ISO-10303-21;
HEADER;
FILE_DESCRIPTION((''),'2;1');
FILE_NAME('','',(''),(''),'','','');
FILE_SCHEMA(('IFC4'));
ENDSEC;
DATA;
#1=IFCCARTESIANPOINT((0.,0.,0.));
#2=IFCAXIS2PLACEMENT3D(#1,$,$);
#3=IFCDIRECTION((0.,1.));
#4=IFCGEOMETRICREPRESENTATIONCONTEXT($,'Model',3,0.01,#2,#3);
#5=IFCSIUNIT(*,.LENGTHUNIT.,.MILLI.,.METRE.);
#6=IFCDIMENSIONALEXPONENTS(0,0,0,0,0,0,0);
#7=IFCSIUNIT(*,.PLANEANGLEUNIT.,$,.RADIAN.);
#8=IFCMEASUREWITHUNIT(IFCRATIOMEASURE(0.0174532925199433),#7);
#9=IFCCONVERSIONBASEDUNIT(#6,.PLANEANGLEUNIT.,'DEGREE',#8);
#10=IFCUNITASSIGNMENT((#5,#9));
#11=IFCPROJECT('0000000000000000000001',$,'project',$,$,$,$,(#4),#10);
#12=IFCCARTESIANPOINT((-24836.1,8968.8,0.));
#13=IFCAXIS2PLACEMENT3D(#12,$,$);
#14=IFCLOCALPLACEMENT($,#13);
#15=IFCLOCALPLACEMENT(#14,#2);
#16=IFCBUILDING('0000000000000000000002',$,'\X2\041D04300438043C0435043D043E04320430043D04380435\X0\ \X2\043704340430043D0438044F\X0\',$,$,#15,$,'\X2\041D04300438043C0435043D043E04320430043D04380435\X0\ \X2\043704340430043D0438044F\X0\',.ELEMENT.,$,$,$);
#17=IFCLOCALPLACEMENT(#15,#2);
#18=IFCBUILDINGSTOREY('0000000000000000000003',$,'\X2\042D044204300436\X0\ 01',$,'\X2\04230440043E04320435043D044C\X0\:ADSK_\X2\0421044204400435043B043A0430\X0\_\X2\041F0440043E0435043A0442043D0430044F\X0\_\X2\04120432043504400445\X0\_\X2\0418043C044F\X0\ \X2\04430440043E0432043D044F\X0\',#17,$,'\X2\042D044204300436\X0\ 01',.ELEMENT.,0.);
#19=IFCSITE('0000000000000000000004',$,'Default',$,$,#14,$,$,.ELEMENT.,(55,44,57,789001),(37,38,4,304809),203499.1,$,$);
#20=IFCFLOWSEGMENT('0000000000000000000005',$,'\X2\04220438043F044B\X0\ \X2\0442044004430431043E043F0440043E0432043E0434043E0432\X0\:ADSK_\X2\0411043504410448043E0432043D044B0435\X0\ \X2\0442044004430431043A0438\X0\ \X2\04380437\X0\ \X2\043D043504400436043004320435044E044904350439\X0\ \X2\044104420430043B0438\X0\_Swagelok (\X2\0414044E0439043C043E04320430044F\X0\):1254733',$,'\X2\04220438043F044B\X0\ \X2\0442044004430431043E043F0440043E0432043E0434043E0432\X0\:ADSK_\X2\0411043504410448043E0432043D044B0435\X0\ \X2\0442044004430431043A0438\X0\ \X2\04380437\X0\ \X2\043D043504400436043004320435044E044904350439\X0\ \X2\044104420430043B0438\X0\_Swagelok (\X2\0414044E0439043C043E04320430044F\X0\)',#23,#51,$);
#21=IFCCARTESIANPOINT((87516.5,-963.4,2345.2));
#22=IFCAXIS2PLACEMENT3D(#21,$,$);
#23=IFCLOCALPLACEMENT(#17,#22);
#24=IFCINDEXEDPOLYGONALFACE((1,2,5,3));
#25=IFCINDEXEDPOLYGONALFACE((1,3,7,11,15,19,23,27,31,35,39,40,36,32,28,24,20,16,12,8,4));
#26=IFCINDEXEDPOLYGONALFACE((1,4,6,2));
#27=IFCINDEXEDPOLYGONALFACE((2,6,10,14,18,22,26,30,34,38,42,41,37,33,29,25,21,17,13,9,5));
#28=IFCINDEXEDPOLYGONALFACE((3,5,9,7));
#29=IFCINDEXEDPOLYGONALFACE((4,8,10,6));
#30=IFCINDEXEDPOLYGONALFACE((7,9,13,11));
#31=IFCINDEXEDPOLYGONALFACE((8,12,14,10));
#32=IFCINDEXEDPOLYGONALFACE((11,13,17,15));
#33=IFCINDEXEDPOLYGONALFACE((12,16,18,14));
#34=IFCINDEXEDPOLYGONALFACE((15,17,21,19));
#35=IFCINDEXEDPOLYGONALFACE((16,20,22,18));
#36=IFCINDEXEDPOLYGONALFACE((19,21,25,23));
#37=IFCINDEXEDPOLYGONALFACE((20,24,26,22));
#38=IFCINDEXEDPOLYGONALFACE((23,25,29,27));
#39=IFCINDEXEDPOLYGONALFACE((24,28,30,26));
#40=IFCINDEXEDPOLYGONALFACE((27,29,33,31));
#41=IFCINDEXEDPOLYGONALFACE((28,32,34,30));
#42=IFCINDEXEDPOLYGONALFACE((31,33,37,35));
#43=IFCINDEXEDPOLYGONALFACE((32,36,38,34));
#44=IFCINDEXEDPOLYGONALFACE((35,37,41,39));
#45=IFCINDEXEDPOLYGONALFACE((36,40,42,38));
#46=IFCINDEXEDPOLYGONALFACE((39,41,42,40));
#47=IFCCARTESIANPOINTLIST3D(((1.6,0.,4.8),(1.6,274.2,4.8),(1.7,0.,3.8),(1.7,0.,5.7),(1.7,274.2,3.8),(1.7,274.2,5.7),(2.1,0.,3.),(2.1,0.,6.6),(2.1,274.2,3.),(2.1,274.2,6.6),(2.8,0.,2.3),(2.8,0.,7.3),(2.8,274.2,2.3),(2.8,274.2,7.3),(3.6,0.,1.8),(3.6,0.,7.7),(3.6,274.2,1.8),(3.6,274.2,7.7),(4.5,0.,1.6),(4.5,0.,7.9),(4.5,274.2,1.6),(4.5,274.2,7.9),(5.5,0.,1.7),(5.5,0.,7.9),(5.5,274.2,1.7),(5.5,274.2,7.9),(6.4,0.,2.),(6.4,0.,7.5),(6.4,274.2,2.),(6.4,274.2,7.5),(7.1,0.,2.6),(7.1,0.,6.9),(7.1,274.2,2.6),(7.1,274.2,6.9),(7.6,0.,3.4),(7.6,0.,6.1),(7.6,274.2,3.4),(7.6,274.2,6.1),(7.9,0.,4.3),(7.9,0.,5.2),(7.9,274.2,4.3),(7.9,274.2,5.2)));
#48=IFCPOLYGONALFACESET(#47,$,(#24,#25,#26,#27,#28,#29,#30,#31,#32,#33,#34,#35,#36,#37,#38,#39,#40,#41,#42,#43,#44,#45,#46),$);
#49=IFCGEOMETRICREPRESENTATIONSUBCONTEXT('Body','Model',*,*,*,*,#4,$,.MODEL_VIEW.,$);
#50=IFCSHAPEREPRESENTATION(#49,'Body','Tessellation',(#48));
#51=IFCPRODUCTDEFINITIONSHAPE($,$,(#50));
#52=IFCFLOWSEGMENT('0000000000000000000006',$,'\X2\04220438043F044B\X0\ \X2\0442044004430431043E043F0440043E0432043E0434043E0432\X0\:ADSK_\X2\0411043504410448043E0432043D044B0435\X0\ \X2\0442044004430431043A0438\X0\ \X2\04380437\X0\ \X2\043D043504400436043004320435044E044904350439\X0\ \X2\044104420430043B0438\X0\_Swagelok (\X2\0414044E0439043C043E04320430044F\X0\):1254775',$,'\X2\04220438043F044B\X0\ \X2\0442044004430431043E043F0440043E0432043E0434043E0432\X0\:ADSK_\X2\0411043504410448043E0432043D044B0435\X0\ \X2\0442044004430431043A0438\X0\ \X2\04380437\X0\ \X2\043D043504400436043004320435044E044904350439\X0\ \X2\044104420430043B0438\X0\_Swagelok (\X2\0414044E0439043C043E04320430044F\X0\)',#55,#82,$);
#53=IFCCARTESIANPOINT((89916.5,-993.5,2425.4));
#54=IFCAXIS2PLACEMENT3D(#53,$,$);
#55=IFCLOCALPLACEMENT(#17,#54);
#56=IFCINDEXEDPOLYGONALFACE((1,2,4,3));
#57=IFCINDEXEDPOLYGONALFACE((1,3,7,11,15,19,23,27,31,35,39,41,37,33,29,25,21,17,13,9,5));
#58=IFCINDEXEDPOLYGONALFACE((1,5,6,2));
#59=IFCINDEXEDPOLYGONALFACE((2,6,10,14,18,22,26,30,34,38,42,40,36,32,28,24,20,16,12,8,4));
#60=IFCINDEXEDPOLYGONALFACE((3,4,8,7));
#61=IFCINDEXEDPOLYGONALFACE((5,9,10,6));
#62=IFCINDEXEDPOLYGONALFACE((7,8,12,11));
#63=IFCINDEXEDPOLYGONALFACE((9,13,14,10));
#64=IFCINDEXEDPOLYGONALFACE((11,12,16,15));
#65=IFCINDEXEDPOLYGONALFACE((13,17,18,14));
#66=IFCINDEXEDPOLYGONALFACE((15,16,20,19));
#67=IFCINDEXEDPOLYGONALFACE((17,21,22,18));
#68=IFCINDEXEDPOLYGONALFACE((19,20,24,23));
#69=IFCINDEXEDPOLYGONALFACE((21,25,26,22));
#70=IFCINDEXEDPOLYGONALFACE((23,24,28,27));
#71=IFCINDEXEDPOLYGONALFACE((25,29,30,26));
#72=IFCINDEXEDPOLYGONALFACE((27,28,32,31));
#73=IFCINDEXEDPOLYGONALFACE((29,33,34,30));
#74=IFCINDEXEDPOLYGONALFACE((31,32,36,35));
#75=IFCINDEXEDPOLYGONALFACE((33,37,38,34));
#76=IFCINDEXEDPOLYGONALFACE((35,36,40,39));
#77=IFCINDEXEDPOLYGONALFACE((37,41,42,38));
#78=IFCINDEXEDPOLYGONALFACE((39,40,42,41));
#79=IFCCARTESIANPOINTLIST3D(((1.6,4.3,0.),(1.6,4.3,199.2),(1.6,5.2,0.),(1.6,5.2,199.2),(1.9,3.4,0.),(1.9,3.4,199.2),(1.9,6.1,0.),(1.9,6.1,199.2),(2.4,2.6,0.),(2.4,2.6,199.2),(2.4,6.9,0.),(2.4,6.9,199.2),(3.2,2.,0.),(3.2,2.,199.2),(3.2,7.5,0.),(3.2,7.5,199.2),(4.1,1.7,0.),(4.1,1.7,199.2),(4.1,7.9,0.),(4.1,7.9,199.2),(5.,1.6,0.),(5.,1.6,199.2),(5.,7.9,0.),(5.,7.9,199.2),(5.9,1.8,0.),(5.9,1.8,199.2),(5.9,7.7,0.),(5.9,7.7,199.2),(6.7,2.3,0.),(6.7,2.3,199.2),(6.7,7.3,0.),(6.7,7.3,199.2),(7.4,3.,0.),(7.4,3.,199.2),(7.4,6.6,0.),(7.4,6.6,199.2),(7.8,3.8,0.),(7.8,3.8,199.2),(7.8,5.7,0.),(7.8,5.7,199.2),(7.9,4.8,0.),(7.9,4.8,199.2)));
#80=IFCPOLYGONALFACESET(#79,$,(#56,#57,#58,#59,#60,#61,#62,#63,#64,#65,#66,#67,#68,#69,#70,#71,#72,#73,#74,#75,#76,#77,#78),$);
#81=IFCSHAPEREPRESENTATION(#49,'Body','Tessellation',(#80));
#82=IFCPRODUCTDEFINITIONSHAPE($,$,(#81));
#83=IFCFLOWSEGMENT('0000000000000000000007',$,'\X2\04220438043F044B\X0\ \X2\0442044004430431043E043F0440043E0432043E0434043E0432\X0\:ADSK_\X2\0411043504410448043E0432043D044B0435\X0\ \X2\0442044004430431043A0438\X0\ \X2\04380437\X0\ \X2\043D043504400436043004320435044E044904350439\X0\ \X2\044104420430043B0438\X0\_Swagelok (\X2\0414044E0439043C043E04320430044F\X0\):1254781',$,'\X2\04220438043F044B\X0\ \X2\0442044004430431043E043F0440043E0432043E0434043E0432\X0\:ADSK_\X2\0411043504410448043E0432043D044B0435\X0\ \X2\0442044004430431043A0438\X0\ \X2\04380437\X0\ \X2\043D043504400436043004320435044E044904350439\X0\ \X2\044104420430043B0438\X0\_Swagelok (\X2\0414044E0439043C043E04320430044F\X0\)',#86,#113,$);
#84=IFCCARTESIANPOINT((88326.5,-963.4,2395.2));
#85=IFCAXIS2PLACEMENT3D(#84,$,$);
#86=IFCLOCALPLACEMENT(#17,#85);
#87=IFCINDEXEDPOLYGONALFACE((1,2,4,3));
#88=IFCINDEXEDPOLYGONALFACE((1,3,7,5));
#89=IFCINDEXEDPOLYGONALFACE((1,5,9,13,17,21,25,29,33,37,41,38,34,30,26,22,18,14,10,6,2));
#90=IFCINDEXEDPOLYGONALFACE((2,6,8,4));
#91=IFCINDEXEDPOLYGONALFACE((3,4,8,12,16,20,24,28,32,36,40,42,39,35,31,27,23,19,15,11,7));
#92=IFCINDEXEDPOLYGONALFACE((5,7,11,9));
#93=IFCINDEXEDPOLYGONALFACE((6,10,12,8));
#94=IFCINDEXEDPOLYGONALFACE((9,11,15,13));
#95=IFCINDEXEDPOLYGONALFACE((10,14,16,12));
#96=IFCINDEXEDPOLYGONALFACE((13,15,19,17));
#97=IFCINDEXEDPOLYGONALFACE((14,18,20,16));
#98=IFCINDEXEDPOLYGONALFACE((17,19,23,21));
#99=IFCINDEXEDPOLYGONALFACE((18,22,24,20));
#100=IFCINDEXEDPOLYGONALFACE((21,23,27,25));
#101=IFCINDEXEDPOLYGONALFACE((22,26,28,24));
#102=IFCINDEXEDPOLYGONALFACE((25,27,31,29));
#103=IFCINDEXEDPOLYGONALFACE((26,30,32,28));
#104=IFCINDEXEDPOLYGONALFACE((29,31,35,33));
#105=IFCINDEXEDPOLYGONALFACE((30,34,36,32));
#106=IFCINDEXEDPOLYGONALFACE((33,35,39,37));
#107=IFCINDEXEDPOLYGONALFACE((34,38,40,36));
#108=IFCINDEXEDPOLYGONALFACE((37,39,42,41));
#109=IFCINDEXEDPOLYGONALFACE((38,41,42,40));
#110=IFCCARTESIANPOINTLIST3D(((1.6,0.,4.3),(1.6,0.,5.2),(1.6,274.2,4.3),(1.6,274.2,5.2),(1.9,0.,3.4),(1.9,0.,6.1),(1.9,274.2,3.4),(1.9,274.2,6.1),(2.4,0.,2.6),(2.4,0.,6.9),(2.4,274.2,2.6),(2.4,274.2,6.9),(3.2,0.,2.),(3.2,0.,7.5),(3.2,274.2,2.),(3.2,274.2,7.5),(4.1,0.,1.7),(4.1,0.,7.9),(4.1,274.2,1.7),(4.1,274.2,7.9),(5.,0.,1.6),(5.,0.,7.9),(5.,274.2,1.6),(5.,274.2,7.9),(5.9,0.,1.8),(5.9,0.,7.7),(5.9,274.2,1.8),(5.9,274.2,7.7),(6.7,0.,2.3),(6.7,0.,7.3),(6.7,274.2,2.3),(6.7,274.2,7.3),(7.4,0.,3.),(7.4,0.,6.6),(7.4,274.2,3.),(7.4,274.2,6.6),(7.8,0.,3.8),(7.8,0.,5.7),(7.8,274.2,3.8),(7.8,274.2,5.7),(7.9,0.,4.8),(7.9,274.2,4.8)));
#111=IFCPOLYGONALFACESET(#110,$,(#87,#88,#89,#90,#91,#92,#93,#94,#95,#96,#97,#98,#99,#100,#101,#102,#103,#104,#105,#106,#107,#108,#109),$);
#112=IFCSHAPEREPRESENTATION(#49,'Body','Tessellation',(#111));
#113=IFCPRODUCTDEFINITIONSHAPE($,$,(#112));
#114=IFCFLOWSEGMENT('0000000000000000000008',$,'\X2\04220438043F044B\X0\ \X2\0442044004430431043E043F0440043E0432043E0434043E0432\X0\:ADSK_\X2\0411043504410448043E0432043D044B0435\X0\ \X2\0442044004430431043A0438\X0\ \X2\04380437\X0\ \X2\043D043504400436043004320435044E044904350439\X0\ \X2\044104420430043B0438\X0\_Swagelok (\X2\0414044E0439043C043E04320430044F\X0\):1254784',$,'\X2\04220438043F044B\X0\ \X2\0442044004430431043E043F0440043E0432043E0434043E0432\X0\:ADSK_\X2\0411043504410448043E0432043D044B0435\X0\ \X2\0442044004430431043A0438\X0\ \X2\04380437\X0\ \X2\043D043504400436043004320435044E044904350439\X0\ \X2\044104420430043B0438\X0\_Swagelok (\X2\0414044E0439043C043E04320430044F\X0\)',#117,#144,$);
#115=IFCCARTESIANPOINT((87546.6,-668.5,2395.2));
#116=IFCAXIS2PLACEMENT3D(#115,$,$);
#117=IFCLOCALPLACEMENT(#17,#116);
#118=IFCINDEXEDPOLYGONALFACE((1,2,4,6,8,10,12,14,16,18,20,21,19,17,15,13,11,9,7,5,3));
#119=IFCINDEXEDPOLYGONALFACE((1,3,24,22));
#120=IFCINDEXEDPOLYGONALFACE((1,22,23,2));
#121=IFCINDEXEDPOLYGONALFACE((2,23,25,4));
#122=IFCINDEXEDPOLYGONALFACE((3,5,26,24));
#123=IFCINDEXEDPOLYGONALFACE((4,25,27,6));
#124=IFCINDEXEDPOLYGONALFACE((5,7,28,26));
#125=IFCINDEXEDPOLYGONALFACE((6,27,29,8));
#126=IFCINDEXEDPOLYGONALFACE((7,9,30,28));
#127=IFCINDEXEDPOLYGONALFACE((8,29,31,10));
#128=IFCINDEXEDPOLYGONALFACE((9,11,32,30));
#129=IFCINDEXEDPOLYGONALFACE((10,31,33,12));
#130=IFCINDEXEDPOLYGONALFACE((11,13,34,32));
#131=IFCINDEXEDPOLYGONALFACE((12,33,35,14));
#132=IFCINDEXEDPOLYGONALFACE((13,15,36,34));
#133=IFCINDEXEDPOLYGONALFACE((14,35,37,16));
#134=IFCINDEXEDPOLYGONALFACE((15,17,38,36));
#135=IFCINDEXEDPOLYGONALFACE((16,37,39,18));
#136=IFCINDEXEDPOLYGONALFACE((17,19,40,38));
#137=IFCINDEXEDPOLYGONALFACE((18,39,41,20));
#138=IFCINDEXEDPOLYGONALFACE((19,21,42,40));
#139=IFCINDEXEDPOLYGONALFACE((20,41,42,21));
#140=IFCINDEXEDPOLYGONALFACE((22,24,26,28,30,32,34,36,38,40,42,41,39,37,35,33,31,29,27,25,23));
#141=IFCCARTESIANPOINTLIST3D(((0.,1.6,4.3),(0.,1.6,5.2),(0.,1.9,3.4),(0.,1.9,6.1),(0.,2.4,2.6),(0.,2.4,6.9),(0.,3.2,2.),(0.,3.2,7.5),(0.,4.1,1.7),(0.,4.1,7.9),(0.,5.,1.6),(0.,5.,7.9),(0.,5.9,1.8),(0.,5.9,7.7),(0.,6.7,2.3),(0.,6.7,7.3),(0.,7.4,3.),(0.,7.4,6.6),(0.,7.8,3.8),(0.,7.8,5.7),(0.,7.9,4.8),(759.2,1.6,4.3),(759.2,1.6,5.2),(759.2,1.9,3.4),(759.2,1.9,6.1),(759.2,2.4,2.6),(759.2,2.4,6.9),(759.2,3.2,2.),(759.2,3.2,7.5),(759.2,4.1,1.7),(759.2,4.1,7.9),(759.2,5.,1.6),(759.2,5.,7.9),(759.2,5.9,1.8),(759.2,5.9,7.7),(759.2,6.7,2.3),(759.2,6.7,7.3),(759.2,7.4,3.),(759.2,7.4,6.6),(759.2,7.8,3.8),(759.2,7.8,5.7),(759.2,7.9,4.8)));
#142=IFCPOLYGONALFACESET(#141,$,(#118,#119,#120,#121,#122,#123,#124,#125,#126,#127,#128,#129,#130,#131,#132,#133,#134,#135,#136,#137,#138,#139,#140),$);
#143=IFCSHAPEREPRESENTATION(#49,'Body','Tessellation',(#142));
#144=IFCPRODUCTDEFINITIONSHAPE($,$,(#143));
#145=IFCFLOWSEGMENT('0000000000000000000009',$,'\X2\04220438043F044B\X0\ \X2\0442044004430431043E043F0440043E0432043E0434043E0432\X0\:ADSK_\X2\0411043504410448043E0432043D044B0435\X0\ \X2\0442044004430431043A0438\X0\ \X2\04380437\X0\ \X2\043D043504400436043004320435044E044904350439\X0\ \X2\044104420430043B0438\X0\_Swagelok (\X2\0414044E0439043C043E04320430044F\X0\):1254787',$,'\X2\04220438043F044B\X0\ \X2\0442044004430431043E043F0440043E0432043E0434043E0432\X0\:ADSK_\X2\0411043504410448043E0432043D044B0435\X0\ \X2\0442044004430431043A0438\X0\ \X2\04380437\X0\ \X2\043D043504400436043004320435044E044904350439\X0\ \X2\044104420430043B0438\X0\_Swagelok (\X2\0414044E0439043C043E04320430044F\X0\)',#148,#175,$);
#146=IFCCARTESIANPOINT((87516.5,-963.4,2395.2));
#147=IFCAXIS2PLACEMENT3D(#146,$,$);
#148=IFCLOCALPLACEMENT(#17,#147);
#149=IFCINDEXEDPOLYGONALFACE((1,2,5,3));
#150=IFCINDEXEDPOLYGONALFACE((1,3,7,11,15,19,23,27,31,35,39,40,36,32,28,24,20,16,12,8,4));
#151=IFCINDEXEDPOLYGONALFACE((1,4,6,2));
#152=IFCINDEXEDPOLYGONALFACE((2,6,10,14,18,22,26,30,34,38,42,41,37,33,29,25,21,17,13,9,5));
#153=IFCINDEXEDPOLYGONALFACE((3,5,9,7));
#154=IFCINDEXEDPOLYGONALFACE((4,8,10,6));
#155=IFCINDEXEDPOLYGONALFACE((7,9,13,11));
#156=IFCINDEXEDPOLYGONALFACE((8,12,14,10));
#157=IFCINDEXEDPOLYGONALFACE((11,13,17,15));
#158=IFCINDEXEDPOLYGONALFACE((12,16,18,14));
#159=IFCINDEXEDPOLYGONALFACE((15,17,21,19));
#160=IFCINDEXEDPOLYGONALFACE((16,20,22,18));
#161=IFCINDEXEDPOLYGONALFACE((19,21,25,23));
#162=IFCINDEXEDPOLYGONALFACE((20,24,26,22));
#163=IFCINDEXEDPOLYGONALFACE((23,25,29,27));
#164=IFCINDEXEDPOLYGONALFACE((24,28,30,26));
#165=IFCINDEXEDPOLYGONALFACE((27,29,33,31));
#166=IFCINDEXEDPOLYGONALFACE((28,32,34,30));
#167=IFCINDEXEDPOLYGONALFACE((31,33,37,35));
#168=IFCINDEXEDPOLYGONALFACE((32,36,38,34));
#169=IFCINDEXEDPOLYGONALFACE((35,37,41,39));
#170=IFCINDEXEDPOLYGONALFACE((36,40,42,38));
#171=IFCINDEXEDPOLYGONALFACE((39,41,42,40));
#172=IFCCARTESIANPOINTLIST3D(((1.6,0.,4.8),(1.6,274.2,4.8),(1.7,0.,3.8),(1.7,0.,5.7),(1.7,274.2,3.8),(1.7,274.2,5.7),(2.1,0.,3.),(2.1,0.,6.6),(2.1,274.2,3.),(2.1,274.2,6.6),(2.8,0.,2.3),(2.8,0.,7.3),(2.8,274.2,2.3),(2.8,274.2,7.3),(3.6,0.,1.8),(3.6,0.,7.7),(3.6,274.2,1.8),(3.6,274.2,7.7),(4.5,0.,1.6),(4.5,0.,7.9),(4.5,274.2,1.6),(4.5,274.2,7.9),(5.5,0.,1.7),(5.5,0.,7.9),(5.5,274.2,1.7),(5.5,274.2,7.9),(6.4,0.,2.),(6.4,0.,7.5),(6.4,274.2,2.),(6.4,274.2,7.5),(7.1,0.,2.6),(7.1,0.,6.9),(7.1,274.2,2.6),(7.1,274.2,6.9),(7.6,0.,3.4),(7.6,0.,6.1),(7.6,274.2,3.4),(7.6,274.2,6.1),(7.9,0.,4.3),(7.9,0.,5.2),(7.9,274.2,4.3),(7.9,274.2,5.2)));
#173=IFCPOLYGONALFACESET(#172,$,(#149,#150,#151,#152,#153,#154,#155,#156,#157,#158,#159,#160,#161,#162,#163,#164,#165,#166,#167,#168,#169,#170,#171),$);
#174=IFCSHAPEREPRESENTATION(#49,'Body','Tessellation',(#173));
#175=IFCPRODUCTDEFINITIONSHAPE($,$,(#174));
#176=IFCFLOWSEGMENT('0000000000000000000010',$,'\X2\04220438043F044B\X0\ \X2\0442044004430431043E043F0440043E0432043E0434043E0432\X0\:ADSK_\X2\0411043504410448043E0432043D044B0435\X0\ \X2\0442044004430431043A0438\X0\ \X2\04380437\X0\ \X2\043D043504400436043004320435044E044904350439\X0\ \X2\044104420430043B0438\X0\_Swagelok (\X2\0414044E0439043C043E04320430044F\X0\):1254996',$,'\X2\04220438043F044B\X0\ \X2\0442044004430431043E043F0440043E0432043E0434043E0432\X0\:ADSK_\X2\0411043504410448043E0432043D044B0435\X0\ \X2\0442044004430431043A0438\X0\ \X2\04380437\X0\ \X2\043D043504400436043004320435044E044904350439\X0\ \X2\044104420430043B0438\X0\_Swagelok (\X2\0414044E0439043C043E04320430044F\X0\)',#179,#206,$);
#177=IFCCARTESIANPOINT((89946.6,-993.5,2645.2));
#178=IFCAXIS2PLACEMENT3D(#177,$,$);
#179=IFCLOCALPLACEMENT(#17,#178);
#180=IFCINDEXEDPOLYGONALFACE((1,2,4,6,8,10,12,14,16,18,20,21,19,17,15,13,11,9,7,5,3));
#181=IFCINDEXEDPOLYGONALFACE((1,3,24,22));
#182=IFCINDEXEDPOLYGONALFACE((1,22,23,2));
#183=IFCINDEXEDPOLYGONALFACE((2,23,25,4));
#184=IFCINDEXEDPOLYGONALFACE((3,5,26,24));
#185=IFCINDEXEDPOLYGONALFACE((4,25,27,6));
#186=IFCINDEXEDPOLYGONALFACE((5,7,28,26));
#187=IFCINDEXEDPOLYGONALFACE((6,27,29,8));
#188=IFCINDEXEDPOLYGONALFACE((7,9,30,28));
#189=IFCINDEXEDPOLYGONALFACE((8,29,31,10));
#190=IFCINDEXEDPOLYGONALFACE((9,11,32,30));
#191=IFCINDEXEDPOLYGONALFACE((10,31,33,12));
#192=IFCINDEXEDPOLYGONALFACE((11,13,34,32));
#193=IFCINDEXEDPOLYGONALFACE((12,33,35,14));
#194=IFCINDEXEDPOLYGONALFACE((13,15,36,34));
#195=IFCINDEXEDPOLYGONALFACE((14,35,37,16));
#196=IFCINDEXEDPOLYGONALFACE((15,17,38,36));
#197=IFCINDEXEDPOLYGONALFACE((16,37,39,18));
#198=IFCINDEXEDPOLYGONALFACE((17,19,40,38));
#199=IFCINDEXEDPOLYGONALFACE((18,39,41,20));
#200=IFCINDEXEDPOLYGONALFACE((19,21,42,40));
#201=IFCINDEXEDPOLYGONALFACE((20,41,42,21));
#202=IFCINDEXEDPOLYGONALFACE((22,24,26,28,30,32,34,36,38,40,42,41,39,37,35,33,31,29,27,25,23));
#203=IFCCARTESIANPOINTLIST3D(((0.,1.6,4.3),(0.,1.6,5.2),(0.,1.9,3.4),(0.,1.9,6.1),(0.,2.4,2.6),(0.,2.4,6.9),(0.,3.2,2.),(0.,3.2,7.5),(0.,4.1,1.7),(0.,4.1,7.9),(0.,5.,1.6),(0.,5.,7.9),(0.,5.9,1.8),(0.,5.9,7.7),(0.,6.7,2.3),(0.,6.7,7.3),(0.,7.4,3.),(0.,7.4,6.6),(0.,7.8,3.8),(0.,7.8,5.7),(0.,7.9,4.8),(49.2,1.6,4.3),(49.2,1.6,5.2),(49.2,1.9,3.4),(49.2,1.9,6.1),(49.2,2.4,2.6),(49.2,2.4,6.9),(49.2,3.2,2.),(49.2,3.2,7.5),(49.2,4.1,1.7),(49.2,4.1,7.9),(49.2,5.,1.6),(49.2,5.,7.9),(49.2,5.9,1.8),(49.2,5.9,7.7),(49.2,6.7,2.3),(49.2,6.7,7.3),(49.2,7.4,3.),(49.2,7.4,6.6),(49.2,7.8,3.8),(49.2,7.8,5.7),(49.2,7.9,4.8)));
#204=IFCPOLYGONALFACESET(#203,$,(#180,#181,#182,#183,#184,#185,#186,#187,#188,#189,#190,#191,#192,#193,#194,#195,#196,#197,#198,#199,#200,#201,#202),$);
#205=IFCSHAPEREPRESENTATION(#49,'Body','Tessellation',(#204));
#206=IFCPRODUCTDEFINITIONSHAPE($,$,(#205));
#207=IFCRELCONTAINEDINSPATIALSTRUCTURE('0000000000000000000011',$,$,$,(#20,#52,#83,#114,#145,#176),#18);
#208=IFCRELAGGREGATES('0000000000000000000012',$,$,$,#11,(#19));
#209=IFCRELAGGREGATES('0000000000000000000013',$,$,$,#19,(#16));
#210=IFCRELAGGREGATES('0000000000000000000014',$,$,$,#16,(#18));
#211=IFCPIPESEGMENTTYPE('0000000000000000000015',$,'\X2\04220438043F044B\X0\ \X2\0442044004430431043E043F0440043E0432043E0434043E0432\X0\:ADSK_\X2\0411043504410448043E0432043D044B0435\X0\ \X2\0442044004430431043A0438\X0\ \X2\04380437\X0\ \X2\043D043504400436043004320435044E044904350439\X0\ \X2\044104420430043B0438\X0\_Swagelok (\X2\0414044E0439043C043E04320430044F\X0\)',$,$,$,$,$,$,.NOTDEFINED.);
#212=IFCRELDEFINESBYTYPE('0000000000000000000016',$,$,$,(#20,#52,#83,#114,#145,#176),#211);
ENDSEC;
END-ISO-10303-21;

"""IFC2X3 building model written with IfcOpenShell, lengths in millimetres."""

from ifc_helpers import new_model, entity, si_unit, converted_unit, direction, frame, origin, origin_2d_with_axis, place, context, subcontext, project, spatial, circle, extrude, type_object, element, save


model = new_model("IFC2X3")

# Units and contexts
model_context = context("Model", 3, precision=0.01, world=origin(), true_north=direction((0.0, 1.0)))
body_context = subcontext(model_context, "Body", "Model", "MODEL_VIEW")
ifc_project = project(units=[si_unit("LENGTHUNIT", "METRE", prefix="MILLI"), converted_unit("PLANEANGLEUNIT", "DEGREE", entity("IfcRatioMeasure", 0.0174532925199433), si_unit("PLANEANGLEUNIT", "RADIAN"), dimensions=[0, 0, 0, 0, 0, 0, 0])], contexts=[model_context])

# Site, building, storey
site_placement = place(None, frame((-24836.1, 8968.8, 0.0)))
site = spatial("IfcSite", under=ifc_project, at=site_placement, Name="Default", CompositionType="ELEMENT", RefLatitude=(55, 44, 57, 789001), RefLongitude=(37, 38, 4, 304809), RefElevation=203499.1)
building_placement = place(site_placement, origin())
building = spatial("IfcBuilding", under=site, at=building_placement, Name="Наименование здания", LongName="Наименование здания", CompositionType="ELEMENT")
storey_placement = place(building_placement, origin())
storey = spatial("IfcBuildingStorey", under=building, at=storey_placement, Name="Этаж 01", ObjectType="Уровень:ADSK_Стрелка_Проектная_Вверх_Имя уровня", LongName="Этаж 01", CompositionType="ELEMENT", Elevation=0.0)

# Flow segments
pipe_segment_type_1 = type_object("IfcPipeSegmentType", Name="Типы трубопроводов:ADSK_Бесшовные трубки из нержавеющей стали_Swagelok (Дюймовая)", PredefinedType="NOTDEFINED")
flow_segment_1_placement = place(storey_placement, frame((87516.5, -963.4, 2345.2)))
element("IfcFlowSegment", 1, at=flow_segment_1_placement, inside=storey, type_object=pipe_segment_type_1, Name="Типы трубопроводов:ADSK_Бесшовные трубки из нержавеющей стали_Swagelok (Дюймовая):1254733", ObjectType="Типы трубопроводов:ADSK_Бесшовные трубки из нержавеющей стали_Swagelok (Дюймовая)", context=body_context, shape_type="SweptSolid", body=[
    extrude(circle(Radius=3.2, at=origin_2d_with_axis()), frame((4.8, 0.0, 4.8), z_axis=(0.0, 1.0, 0.0), x_axis=(-1.0, 0.0, 0.0)), (0.0, 0.0, 1.0), 274.2),
])
flow_segment_2_placement = place(storey_placement, frame((89916.5, -993.5, 2425.4)))
element("IfcFlowSegment", 2, at=flow_segment_2_placement, inside=storey, type_object=pipe_segment_type_1, Name="Типы трубопроводов:ADSK_Бесшовные трубки из нержавеющей стали_Swagelok (Дюймовая):1254775", ObjectType="Типы трубопроводов:ADSK_Бесшовные трубки из нержавеющей стали_Swagelok (Дюймовая)", context=body_context, shape_type="SweptSolid", body=[
    extrude(circle(Radius=3.2, at=origin_2d_with_axis()), frame((4.8, 4.8, 0.0)), (0.0, 0.0, 1.0), 199.2),
])
flow_segment_3_placement = place(storey_placement, frame((88326.5, -963.4, 2395.2)))
element("IfcFlowSegment", 3, at=flow_segment_3_placement, inside=storey, type_object=pipe_segment_type_1, Name="Типы трубопроводов:ADSK_Бесшовные трубки из нержавеющей стали_Swagelok (Дюймовая):1254781", ObjectType="Типы трубопроводов:ADSK_Бесшовные трубки из нержавеющей стали_Swagelok (Дюймовая)", context=body_context, shape_type="SweptSolid", body=[
    extrude(circle(Radius=3.2, at=origin_2d_with_axis()), frame((4.8, 0.0, 4.8), z_axis=(0.0, 1.0, 0.0), x_axis=(1.0, 0.0, 0.0)), (0.0, 0.0, 1.0), 274.2),
])
flow_segment_4_placement = place(storey_placement, frame((87546.6, -668.5, 2395.2)))
element("IfcFlowSegment", 4, at=flow_segment_4_placement, inside=storey, type_object=pipe_segment_type_1, Name="Типы трубопроводов:ADSK_Бесшовные трубки из нержавеющей стали_Swagelok (Дюймовая):1254784", ObjectType="Типы трубопроводов:ADSK_Бесшовные трубки из нержавеющей стали_Swagelok (Дюймовая)", context=body_context, shape_type="SweptSolid", body=[
    extrude(circle(Radius=3.2, at=origin_2d_with_axis()), frame((0.0, 4.8, 4.8), z_axis=(1.0, 0.0, 0.0), x_axis=(0.0, 1.0, 0.0)), (0.0, 0.0, 1.0), 759.2),
])
flow_segment_5_placement = place(storey_placement, frame((87516.5, -963.4, 2395.2)))
element("IfcFlowSegment", 5, at=flow_segment_5_placement, inside=storey, type_object=pipe_segment_type_1, Name="Типы трубопроводов:ADSK_Бесшовные трубки из нержавеющей стали_Swagelok (Дюймовая):1254787", ObjectType="Типы трубопроводов:ADSK_Бесшовные трубки из нержавеющей стали_Swagelok (Дюймовая)", context=body_context, shape_type="SweptSolid", body=[
    extrude(circle(Radius=3.2, at=origin_2d_with_axis()), frame((4.8, 0.0, 4.8), z_axis=(0.0, 1.0, 0.0), x_axis=(-1.0, 0.0, 0.0)), (0.0, 0.0, 1.0), 274.2),
])
flow_segment_6_placement = place(storey_placement, frame((89946.6, -993.5, 2645.2)))
element("IfcFlowSegment", 6, at=flow_segment_6_placement, inside=storey, type_object=pipe_segment_type_1, Name="Типы трубопроводов:ADSK_Бесшовные трубки из нержавеющей стали_Swagelok (Дюймовая):1254996", ObjectType="Типы трубопроводов:ADSK_Бесшовные трубки из нержавеющей стали_Swagelok (Дюймовая)", context=body_context, shape_type="SweptSolid", body=[
    extrude(circle(Radius=3.2, at=origin_2d_with_axis()), frame((0.0, 4.8, 4.8), z_axis=(1.0, 0.0, 0.0), x_axis=(0.0, 1.0, 0.0)), (0.0, 0.0, 1.0), 49.2),
])

save(model, "model.ifc")
